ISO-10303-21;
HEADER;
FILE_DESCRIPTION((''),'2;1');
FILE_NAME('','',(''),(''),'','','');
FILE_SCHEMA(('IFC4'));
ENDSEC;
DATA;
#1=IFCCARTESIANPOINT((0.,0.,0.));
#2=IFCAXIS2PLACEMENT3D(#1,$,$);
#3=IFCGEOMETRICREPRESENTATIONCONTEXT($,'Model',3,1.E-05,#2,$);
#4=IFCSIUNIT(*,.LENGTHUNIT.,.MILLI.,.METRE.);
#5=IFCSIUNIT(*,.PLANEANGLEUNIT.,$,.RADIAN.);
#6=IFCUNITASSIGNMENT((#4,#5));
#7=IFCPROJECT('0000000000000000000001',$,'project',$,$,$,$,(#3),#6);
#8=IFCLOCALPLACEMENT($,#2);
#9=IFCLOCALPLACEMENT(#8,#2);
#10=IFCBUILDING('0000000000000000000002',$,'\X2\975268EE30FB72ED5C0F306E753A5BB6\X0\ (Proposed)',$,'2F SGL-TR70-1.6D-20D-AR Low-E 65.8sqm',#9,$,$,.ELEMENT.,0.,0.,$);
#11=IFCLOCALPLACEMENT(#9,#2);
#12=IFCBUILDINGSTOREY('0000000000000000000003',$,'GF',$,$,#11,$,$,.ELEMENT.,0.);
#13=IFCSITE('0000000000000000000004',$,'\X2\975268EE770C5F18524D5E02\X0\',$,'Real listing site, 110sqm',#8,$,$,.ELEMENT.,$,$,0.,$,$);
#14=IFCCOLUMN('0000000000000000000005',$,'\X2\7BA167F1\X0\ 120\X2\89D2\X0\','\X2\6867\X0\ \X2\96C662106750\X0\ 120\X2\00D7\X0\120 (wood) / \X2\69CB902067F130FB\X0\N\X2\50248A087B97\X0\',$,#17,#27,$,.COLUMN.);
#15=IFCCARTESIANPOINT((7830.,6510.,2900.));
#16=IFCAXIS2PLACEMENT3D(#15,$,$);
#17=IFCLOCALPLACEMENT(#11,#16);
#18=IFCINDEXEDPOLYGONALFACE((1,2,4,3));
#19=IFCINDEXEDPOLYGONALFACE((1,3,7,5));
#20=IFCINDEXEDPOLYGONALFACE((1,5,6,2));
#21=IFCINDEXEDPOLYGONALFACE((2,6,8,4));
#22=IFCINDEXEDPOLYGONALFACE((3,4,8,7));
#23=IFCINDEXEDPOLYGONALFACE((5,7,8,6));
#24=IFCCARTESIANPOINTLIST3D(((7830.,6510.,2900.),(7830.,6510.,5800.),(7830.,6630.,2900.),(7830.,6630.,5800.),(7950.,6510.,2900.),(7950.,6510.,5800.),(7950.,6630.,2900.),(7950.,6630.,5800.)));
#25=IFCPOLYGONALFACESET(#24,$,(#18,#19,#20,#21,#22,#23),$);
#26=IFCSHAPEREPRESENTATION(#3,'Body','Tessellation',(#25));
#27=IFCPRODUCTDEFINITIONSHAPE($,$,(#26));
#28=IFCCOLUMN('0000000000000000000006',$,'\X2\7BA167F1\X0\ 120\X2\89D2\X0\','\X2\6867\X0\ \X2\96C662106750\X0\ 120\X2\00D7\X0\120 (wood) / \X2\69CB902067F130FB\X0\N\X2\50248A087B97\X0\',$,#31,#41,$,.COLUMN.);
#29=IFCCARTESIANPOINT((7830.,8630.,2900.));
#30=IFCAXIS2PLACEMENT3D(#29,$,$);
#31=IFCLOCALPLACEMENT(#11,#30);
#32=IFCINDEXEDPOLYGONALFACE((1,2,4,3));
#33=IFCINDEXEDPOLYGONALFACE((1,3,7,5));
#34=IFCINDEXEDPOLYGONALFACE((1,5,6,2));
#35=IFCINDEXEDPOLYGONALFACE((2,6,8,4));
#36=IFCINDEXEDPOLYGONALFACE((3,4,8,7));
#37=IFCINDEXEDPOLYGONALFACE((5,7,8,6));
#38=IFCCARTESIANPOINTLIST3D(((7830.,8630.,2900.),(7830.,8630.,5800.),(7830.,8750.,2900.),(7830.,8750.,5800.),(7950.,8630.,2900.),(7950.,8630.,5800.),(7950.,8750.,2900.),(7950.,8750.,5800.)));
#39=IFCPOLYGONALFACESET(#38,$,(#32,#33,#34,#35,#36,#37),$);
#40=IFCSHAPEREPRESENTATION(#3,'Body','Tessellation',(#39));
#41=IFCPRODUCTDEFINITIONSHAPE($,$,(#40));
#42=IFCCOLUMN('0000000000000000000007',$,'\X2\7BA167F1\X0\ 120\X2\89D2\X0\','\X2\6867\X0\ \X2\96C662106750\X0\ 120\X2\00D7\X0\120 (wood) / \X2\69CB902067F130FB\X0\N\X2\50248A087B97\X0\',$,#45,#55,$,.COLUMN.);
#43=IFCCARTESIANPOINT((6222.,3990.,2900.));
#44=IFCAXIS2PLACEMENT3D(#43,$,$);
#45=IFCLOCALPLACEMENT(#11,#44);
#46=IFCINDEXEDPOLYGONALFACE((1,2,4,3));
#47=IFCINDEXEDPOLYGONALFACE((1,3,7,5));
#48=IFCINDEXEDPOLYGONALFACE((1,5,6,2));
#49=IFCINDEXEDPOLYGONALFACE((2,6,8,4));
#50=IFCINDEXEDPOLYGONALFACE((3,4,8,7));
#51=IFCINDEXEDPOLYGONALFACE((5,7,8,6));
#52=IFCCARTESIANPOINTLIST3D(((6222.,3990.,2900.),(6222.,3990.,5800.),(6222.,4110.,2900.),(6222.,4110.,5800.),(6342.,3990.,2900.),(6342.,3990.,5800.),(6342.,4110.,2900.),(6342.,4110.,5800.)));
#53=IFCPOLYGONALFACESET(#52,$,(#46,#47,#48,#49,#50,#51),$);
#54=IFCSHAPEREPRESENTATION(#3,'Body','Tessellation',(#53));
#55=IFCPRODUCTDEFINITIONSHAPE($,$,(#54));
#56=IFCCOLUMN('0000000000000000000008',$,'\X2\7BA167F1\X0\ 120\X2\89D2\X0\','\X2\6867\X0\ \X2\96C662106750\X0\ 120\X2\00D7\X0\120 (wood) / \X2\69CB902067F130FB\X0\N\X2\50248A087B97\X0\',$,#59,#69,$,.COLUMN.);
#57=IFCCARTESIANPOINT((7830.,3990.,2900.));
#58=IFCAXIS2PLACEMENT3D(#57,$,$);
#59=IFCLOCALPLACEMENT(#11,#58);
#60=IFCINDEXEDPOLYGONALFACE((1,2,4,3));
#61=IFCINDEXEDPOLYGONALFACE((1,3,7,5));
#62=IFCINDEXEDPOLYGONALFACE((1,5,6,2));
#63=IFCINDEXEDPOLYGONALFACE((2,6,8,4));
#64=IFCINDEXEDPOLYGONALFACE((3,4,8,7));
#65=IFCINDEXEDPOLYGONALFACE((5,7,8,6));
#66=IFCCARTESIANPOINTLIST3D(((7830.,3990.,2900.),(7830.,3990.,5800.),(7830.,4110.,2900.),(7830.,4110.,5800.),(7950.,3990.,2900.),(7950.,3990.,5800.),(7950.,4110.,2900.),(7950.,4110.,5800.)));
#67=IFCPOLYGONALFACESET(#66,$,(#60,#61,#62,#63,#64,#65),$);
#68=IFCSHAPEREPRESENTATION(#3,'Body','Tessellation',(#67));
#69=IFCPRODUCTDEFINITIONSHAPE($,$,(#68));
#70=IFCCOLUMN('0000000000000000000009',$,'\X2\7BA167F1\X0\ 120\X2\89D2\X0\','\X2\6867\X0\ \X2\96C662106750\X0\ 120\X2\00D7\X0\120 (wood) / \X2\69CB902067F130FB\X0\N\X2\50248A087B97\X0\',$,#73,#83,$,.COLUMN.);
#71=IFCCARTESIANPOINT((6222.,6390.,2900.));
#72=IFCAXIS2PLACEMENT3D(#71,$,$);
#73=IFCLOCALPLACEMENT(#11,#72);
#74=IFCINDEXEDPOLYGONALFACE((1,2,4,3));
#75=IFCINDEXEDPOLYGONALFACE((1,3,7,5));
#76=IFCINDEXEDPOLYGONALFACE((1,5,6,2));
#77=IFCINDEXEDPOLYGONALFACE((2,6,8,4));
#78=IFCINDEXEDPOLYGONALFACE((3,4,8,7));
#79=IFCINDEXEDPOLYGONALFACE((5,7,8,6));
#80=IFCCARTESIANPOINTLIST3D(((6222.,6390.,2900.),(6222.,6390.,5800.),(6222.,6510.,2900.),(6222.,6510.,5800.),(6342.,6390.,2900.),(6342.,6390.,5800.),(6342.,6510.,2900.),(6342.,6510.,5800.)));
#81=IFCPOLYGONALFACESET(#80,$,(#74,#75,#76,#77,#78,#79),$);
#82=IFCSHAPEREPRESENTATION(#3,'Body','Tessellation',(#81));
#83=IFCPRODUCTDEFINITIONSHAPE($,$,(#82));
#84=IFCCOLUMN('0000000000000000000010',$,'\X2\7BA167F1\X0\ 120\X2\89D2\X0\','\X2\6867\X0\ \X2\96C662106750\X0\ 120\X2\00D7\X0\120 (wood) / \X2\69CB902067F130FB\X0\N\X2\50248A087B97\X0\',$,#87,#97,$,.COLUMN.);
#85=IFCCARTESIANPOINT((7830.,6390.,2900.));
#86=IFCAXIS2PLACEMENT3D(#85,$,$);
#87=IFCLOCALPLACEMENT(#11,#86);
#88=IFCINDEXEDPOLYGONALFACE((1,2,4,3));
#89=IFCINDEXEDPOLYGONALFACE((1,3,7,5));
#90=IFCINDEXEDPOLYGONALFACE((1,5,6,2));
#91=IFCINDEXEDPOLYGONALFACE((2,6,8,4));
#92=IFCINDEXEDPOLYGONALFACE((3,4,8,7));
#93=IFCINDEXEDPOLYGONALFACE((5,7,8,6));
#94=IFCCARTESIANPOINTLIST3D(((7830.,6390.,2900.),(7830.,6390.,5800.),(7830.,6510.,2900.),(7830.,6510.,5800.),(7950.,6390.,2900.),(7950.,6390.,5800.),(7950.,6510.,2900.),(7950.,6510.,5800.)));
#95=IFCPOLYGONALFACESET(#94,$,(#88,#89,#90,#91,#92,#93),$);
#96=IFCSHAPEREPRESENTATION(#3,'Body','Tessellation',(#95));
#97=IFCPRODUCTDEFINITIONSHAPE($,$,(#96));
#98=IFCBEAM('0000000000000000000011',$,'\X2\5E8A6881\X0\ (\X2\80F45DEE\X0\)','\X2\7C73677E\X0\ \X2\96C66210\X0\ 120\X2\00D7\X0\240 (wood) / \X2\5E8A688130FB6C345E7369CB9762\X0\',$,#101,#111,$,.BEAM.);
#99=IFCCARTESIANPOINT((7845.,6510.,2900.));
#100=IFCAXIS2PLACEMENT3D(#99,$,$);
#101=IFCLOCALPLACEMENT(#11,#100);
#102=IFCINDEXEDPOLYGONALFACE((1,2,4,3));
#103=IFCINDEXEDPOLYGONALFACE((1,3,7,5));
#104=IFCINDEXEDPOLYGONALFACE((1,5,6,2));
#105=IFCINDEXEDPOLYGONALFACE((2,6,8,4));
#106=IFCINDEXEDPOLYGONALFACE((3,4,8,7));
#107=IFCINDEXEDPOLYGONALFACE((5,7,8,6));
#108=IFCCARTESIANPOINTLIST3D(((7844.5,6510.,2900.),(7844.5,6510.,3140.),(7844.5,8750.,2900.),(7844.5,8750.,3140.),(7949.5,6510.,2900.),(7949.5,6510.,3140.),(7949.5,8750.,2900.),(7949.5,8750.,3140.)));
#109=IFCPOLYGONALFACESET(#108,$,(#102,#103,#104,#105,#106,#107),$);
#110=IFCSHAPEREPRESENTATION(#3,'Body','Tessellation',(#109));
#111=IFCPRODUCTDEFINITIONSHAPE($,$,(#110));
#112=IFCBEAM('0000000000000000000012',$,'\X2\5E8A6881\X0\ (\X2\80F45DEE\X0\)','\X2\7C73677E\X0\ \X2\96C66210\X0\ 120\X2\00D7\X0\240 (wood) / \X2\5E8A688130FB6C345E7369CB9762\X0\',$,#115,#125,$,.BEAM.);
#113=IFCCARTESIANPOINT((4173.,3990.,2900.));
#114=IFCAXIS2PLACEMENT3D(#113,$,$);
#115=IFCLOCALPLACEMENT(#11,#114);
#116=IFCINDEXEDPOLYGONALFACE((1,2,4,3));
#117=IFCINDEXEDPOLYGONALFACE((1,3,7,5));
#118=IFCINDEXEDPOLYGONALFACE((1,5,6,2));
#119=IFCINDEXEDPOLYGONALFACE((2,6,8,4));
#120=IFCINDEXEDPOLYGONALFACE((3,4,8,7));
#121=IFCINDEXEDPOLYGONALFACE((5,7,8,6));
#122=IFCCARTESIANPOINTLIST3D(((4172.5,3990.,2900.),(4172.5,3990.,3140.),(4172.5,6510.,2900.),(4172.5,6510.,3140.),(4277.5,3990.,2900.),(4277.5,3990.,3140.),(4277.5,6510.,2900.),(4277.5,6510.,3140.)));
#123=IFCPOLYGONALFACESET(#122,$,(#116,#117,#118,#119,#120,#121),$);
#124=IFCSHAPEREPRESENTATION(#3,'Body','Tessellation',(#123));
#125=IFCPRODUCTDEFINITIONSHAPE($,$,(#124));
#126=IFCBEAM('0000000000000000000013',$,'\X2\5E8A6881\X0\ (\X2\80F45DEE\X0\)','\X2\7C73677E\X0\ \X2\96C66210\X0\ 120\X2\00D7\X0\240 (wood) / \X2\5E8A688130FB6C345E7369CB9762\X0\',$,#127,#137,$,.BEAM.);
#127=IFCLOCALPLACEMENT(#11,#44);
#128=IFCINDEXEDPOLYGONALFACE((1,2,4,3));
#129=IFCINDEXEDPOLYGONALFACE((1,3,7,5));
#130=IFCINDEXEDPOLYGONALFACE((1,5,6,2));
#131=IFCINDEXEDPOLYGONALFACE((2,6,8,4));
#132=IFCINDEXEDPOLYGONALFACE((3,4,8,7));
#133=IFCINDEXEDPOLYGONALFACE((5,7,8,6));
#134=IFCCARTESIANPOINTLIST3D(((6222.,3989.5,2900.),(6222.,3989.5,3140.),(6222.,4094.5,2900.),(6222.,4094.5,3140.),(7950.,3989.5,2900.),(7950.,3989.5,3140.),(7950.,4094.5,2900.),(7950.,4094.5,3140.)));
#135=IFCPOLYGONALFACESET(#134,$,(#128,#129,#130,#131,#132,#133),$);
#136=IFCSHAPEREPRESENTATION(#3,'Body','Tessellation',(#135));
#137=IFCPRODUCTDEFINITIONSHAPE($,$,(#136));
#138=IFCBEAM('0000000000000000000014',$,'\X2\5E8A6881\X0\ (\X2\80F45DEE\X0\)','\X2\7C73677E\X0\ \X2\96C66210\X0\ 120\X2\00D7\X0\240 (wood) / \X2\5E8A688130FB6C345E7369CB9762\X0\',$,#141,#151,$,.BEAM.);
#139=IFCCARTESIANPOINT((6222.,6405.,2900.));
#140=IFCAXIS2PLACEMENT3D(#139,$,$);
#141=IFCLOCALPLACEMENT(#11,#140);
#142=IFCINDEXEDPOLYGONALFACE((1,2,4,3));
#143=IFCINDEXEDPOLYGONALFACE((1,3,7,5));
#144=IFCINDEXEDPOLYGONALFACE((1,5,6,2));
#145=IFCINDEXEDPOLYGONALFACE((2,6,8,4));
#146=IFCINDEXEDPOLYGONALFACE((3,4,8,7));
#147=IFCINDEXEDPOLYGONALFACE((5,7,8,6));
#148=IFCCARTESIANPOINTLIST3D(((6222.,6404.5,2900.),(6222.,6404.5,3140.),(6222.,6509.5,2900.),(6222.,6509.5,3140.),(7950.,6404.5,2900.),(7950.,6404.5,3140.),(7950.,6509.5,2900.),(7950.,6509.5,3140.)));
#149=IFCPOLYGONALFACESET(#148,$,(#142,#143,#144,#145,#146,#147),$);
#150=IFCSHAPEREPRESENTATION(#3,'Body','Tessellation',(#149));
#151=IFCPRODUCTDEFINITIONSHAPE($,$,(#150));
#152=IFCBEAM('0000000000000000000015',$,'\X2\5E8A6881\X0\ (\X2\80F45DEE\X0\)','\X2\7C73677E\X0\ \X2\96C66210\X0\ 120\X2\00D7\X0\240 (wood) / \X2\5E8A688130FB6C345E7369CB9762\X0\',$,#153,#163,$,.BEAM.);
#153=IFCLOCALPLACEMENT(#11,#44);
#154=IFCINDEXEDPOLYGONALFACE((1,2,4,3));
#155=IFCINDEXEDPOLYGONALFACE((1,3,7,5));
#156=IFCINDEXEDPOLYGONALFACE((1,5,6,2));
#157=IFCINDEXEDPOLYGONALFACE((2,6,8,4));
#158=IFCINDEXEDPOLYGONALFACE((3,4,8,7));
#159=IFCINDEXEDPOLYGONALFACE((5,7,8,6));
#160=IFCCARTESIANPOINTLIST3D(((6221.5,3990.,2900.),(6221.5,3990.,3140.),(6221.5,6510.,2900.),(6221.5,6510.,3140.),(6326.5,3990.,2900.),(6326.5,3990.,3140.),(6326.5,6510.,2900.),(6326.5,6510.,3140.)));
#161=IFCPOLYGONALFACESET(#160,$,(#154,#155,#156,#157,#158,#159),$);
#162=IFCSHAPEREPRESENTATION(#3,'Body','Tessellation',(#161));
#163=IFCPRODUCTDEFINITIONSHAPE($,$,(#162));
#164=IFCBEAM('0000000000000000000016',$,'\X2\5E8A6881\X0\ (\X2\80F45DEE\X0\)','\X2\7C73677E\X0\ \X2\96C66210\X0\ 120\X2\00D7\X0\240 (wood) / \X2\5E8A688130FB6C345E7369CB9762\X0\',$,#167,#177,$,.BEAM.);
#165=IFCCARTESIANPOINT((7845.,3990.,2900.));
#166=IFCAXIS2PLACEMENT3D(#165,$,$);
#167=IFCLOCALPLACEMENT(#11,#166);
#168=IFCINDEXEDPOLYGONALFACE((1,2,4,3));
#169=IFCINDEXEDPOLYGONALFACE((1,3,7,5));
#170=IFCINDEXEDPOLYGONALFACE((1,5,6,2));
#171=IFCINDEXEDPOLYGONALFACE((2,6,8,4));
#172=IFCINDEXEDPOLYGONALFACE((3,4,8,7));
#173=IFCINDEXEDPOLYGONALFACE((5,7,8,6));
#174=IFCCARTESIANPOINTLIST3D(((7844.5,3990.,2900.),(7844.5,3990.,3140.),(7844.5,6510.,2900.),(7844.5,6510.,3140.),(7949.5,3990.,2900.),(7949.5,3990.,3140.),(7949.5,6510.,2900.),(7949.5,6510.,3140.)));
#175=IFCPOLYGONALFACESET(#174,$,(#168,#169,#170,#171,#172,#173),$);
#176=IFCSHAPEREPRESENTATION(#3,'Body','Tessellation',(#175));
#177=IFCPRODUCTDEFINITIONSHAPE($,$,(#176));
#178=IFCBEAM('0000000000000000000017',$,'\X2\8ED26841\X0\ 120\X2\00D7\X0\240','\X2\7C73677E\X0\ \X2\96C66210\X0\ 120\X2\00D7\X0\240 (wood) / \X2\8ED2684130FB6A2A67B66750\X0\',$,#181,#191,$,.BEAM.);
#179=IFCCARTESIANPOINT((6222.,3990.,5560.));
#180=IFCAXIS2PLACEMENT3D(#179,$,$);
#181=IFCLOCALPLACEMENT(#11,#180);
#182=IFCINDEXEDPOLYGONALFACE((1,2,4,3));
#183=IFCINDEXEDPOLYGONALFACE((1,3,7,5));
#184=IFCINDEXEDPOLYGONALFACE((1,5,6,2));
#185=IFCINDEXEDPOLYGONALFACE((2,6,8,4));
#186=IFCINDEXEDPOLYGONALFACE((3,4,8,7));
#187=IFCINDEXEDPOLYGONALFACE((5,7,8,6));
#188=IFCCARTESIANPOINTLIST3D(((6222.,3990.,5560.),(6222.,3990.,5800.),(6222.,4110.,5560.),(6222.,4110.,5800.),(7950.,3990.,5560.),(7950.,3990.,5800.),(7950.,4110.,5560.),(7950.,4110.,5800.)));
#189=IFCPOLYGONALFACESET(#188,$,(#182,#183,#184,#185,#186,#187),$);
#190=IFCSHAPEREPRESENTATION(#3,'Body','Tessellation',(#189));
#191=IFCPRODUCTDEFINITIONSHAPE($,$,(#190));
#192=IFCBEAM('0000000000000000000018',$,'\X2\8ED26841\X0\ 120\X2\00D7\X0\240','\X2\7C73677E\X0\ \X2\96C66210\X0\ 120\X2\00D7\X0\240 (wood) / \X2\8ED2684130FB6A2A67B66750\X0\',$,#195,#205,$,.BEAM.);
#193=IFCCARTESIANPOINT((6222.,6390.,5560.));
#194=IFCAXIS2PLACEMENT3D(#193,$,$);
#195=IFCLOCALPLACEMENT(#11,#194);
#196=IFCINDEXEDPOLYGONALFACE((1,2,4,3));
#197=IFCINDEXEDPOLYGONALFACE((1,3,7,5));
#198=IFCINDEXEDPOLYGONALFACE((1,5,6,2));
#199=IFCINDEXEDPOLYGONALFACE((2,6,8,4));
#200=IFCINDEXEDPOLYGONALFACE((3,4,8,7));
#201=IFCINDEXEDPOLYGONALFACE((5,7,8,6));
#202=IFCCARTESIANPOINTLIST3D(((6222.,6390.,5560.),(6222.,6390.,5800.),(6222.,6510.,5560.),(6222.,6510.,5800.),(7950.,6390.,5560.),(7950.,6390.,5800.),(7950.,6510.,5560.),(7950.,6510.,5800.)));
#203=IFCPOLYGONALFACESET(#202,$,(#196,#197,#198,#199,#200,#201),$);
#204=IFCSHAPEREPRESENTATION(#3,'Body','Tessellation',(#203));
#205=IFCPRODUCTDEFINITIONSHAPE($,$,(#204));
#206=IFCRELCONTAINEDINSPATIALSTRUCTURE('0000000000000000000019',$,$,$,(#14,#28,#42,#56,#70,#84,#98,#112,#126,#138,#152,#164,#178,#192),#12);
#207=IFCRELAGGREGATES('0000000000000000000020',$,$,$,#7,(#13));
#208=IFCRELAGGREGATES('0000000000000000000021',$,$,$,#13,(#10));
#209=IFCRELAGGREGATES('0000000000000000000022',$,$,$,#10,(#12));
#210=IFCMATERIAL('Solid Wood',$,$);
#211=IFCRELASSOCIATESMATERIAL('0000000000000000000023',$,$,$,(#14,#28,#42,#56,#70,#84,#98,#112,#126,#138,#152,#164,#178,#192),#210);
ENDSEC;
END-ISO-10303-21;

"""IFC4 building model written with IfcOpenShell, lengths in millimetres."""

from ifc_helpers import new_model, si_unit, frame, frame_2d, origin, place, context, project, spatial, rectangle, extrude, material, element, save


model = new_model("IFC4")

# Units and contexts
model_context = context("Model", 3, precision=1e-05, world=origin())
ifc_project = project(units=[si_unit("LENGTHUNIT", "METRE", prefix="MILLI"), si_unit("PLANEANGLEUNIT", "RADIAN")], contexts=[model_context])

# Site, building, storey
site_placement = place(None, origin())
site = spatial("IfcSite", under=ifc_project, at=site_placement, Name="青森県弘前市", ObjectType="Real listing site, 110sqm", CompositionType="ELEMENT", RefElevation=0.0)
building_placement = place(site_placement, origin())
building = spatial("IfcBuilding", under=site, at=building_placement, Name="青森・狭小の町家 (Proposed)", ObjectType="2F SGL-TR70-1.6D-20D-AR Low-E 65.8sqm", CompositionType="ELEMENT", ElevationOfRefHeight=0.0, ElevationOfTerrain=0.0)
storey_placement = place(building_placement, origin())
storey = spatial("IfcBuildingStorey", under=building, at=storey_placement, Name="GF", CompositionType="ELEMENT", Elevation=0.0)

# Columns
ifc_material_1 = material(Name="Solid Wood")
column_1_placement = place(storey_placement, frame((7830.0, 6510.0, 2900.0)))
element("IfcColumn", 1, at=column_1_placement, inside=storey, material=ifc_material_1, Name="管柱 120角", Description="桧 集成材 120×120 (wood) / 構造柱・N値計算", PredefinedType="COLUMN", context=model_context, shape_type="SweptSolid", body=[
    extrude(rectangle(XDim=120.0, YDim=120.0, at=frame_2d((60.0, 60.0))), frame((7830.0, 6510.0, 2900.0)), (0.0, 0.0, 1.0), 2900.0),
])
column_2_placement = place(storey_placement, frame((7830.0, 8630.0, 2900.0)))
element("IfcColumn", 2, at=column_2_placement, inside=storey, material=ifc_material_1, Name="管柱 120角", Description="桧 集成材 120×120 (wood) / 構造柱・N値計算", PredefinedType="COLUMN", context=model_context, shape_type="SweptSolid", body=[
    extrude(rectangle(XDim=120.0, YDim=120.0, at=frame_2d((60.0, 60.0))), frame((7830.0, 8630.0, 2900.0)), (0.0, 0.0, 1.0), 2900.0),
])
column_3_placement = place(storey_placement, frame((6222.0, 3990.0, 2900.0)))
element("IfcColumn", 3, at=column_3_placement, inside=storey, material=ifc_material_1, Name="管柱 120角", Description="桧 集成材 120×120 (wood) / 構造柱・N値計算", PredefinedType="COLUMN", context=model_context, shape_type="SweptSolid", body=[
    extrude(rectangle(XDim=120.0, YDim=120.0, at=frame_2d((60.0, 60.0))), frame((6222.0, 3990.0, 2900.0)), (0.0, 0.0, 1.0), 2900.0),
])
column_4_placement = place(storey_placement, frame((7830.0, 3990.0, 2900.0)))
element("IfcColumn", 4, at=column_4_placement, inside=storey, material=ifc_material_1, Name="管柱 120角", Description="桧 集成材 120×120 (wood) / 構造柱・N値計算", PredefinedType="COLUMN", context=model_context, shape_type="SweptSolid", body=[
    extrude(rectangle(XDim=120.0, YDim=120.0, at=frame_2d((60.0, 60.0))), frame((7830.0, 3990.0, 2900.0)), (0.0, 0.0, 1.0), 2900.0),
])
column_5_placement = place(storey_placement, frame((6222.0, 6390.0, 2900.0)))
element("IfcColumn", 5, at=column_5_placement, inside=storey, material=ifc_material_1, Name="管柱 120角", Description="桧 集成材 120×120 (wood) / 構造柱・N値計算", PredefinedType="COLUMN", context=model_context, shape_type="SweptSolid", body=[
    extrude(rectangle(XDim=120.0, YDim=120.0, at=frame_2d((60.0, 60.0))), frame((6222.0, 6390.0, 2900.0)), (0.0, 0.0, 1.0), 2900.0),
])
column_6_placement = place(storey_placement, frame((7830.0, 6390.0, 2900.0)))
element("IfcColumn", 6, at=column_6_placement, inside=storey, material=ifc_material_1, Name="管柱 120角", Description="桧 集成材 120×120 (wood) / 構造柱・N値計算", PredefinedType="COLUMN", context=model_context, shape_type="SweptSolid", body=[
    extrude(rectangle(XDim=120.0, YDim=120.0, at=frame_2d((60.0, 60.0))), frame((7830.0, 6390.0, 2900.0)), (0.0, 0.0, 1.0), 2900.0),
])

# Beams
beam_1_placement = place(storey_placement, frame((7845.0, 6510.0, 2900.0)))
element("IfcBeam", 7, at=beam_1_placement, inside=storey, material=ifc_material_1, Name="床梁 (胴差)", Description="米松 集成 120×240 (wood) / 床梁・水平構面", PredefinedType="BEAM", context=model_context, shape_type="SweptSolid", body=[
    extrude(rectangle(XDim=105.0, YDim=2240.0, at=frame_2d((52.0, 1120.0))), frame((7845.0, 6510.0, 2900.0)), (0.0, 0.0, 1.0), 240.0),
])
beam_2_placement = place(storey_placement, frame((4173.0, 3990.0, 2900.0)))
element("IfcBeam", 8, at=beam_2_placement, inside=storey, material=ifc_material_1, Name="床梁 (胴差)", Description="米松 集成 120×240 (wood) / 床梁・水平構面", PredefinedType="BEAM", context=model_context, shape_type="SweptSolid", body=[
    extrude(rectangle(XDim=105.0, YDim=2520.0, at=frame_2d((52.0, 1260.0))), frame((4173.0, 3990.0, 2900.0)), (0.0, 0.0, 1.0), 240.0),
])
beam_3_placement = place(storey_placement, frame((6222.0, 3990.0, 2900.0)))
element("IfcBeam", 9, at=beam_3_placement, inside=storey, material=ifc_material_1, Name="床梁 (胴差)", Description="米松 集成 120×240 (wood) / 床梁・水平構面", PredefinedType="BEAM", context=model_context, shape_type="SweptSolid", body=[
    extrude(rectangle(XDim=1728.0, YDim=105.0, at=frame_2d((864.0, 52.0))), frame((6222.0, 3990.0, 2900.0)), (0.0, 0.0, 1.0), 240.0),
])
beam_4_placement = place(storey_placement, frame((6222.0, 6405.0, 2900.0)))
element("IfcBeam", 10, at=beam_4_placement, inside=storey, material=ifc_material_1, Name="床梁 (胴差)", Description="米松 集成 120×240 (wood) / 床梁・水平構面", PredefinedType="BEAM", context=model_context, shape_type="SweptSolid", body=[
    extrude(rectangle(XDim=1728.0, YDim=105.0, at=frame_2d((864.0, 52.0))), frame((6222.0, 6405.0, 2900.0)), (0.0, 0.0, 1.0), 240.0),
])
beam_5_placement = place(storey_placement, frame((6222.0, 3990.0, 2900.0)))
element("IfcBeam", 11, at=beam_5_placement, inside=storey, material=ifc_material_1, Name="床梁 (胴差)", Description="米松 集成 120×240 (wood) / 床梁・水平構面", PredefinedType="BEAM", context=model_context, shape_type="SweptSolid", body=[
    extrude(rectangle(XDim=105.0, YDim=2520.0, at=frame_2d((52.0, 1260.0))), frame((6222.0, 3990.0, 2900.0)), (0.0, 0.0, 1.0), 240.0),
])
beam_6_placement = place(storey_placement, frame((7845.0, 3990.0, 2900.0)))
element("IfcBeam", 12, at=beam_6_placement, inside=storey, material=ifc_material_1, Name="床梁 (胴差)", Description="米松 集成 120×240 (wood) / 床梁・水平構面", PredefinedType="BEAM", context=model_context, shape_type="SweptSolid", body=[
    extrude(rectangle(XDim=105.0, YDim=2520.0, at=frame_2d((52.0, 1260.0))), frame((7845.0, 3990.0, 2900.0)), (0.0, 0.0, 1.0), 240.0),
])
beam_7_placement = place(storey_placement, frame((6222.0, 3990.0, 5560.0)))
element("IfcBeam", 13, at=beam_7_placement, inside=storey, material=ifc_material_1, Name="軒桁 120×240", Description="米松 集成 120×240 (wood) / 軒桁・横架材", PredefinedType="BEAM", context=model_context, shape_type="SweptSolid", body=[
    extrude(rectangle(XDim=1728.0, YDim=120.0, at=frame_2d((864.0, 60.0))), frame((6222.0, 3990.0, 5560.0)), (0.0, 0.0, 1.0), 240.0),
])
beam_8_placement = place(storey_placement, frame((6222.0, 6390.0, 5560.0)))
element("IfcBeam", 14, at=beam_8_placement, inside=storey, material=ifc_material_1, Name="軒桁 120×240", Description="米松 集成 120×240 (wood) / 軒桁・横架材", PredefinedType="BEAM", context=model_context, shape_type="SweptSolid", body=[
    extrude(rectangle(XDim=1728.0, YDim=120.0, at=frame_2d((864.0, 60.0))), frame((6222.0, 6390.0, 5560.0)), (0.0, 0.0, 1.0), 240.0),
])

save(model, "model.ifc")
